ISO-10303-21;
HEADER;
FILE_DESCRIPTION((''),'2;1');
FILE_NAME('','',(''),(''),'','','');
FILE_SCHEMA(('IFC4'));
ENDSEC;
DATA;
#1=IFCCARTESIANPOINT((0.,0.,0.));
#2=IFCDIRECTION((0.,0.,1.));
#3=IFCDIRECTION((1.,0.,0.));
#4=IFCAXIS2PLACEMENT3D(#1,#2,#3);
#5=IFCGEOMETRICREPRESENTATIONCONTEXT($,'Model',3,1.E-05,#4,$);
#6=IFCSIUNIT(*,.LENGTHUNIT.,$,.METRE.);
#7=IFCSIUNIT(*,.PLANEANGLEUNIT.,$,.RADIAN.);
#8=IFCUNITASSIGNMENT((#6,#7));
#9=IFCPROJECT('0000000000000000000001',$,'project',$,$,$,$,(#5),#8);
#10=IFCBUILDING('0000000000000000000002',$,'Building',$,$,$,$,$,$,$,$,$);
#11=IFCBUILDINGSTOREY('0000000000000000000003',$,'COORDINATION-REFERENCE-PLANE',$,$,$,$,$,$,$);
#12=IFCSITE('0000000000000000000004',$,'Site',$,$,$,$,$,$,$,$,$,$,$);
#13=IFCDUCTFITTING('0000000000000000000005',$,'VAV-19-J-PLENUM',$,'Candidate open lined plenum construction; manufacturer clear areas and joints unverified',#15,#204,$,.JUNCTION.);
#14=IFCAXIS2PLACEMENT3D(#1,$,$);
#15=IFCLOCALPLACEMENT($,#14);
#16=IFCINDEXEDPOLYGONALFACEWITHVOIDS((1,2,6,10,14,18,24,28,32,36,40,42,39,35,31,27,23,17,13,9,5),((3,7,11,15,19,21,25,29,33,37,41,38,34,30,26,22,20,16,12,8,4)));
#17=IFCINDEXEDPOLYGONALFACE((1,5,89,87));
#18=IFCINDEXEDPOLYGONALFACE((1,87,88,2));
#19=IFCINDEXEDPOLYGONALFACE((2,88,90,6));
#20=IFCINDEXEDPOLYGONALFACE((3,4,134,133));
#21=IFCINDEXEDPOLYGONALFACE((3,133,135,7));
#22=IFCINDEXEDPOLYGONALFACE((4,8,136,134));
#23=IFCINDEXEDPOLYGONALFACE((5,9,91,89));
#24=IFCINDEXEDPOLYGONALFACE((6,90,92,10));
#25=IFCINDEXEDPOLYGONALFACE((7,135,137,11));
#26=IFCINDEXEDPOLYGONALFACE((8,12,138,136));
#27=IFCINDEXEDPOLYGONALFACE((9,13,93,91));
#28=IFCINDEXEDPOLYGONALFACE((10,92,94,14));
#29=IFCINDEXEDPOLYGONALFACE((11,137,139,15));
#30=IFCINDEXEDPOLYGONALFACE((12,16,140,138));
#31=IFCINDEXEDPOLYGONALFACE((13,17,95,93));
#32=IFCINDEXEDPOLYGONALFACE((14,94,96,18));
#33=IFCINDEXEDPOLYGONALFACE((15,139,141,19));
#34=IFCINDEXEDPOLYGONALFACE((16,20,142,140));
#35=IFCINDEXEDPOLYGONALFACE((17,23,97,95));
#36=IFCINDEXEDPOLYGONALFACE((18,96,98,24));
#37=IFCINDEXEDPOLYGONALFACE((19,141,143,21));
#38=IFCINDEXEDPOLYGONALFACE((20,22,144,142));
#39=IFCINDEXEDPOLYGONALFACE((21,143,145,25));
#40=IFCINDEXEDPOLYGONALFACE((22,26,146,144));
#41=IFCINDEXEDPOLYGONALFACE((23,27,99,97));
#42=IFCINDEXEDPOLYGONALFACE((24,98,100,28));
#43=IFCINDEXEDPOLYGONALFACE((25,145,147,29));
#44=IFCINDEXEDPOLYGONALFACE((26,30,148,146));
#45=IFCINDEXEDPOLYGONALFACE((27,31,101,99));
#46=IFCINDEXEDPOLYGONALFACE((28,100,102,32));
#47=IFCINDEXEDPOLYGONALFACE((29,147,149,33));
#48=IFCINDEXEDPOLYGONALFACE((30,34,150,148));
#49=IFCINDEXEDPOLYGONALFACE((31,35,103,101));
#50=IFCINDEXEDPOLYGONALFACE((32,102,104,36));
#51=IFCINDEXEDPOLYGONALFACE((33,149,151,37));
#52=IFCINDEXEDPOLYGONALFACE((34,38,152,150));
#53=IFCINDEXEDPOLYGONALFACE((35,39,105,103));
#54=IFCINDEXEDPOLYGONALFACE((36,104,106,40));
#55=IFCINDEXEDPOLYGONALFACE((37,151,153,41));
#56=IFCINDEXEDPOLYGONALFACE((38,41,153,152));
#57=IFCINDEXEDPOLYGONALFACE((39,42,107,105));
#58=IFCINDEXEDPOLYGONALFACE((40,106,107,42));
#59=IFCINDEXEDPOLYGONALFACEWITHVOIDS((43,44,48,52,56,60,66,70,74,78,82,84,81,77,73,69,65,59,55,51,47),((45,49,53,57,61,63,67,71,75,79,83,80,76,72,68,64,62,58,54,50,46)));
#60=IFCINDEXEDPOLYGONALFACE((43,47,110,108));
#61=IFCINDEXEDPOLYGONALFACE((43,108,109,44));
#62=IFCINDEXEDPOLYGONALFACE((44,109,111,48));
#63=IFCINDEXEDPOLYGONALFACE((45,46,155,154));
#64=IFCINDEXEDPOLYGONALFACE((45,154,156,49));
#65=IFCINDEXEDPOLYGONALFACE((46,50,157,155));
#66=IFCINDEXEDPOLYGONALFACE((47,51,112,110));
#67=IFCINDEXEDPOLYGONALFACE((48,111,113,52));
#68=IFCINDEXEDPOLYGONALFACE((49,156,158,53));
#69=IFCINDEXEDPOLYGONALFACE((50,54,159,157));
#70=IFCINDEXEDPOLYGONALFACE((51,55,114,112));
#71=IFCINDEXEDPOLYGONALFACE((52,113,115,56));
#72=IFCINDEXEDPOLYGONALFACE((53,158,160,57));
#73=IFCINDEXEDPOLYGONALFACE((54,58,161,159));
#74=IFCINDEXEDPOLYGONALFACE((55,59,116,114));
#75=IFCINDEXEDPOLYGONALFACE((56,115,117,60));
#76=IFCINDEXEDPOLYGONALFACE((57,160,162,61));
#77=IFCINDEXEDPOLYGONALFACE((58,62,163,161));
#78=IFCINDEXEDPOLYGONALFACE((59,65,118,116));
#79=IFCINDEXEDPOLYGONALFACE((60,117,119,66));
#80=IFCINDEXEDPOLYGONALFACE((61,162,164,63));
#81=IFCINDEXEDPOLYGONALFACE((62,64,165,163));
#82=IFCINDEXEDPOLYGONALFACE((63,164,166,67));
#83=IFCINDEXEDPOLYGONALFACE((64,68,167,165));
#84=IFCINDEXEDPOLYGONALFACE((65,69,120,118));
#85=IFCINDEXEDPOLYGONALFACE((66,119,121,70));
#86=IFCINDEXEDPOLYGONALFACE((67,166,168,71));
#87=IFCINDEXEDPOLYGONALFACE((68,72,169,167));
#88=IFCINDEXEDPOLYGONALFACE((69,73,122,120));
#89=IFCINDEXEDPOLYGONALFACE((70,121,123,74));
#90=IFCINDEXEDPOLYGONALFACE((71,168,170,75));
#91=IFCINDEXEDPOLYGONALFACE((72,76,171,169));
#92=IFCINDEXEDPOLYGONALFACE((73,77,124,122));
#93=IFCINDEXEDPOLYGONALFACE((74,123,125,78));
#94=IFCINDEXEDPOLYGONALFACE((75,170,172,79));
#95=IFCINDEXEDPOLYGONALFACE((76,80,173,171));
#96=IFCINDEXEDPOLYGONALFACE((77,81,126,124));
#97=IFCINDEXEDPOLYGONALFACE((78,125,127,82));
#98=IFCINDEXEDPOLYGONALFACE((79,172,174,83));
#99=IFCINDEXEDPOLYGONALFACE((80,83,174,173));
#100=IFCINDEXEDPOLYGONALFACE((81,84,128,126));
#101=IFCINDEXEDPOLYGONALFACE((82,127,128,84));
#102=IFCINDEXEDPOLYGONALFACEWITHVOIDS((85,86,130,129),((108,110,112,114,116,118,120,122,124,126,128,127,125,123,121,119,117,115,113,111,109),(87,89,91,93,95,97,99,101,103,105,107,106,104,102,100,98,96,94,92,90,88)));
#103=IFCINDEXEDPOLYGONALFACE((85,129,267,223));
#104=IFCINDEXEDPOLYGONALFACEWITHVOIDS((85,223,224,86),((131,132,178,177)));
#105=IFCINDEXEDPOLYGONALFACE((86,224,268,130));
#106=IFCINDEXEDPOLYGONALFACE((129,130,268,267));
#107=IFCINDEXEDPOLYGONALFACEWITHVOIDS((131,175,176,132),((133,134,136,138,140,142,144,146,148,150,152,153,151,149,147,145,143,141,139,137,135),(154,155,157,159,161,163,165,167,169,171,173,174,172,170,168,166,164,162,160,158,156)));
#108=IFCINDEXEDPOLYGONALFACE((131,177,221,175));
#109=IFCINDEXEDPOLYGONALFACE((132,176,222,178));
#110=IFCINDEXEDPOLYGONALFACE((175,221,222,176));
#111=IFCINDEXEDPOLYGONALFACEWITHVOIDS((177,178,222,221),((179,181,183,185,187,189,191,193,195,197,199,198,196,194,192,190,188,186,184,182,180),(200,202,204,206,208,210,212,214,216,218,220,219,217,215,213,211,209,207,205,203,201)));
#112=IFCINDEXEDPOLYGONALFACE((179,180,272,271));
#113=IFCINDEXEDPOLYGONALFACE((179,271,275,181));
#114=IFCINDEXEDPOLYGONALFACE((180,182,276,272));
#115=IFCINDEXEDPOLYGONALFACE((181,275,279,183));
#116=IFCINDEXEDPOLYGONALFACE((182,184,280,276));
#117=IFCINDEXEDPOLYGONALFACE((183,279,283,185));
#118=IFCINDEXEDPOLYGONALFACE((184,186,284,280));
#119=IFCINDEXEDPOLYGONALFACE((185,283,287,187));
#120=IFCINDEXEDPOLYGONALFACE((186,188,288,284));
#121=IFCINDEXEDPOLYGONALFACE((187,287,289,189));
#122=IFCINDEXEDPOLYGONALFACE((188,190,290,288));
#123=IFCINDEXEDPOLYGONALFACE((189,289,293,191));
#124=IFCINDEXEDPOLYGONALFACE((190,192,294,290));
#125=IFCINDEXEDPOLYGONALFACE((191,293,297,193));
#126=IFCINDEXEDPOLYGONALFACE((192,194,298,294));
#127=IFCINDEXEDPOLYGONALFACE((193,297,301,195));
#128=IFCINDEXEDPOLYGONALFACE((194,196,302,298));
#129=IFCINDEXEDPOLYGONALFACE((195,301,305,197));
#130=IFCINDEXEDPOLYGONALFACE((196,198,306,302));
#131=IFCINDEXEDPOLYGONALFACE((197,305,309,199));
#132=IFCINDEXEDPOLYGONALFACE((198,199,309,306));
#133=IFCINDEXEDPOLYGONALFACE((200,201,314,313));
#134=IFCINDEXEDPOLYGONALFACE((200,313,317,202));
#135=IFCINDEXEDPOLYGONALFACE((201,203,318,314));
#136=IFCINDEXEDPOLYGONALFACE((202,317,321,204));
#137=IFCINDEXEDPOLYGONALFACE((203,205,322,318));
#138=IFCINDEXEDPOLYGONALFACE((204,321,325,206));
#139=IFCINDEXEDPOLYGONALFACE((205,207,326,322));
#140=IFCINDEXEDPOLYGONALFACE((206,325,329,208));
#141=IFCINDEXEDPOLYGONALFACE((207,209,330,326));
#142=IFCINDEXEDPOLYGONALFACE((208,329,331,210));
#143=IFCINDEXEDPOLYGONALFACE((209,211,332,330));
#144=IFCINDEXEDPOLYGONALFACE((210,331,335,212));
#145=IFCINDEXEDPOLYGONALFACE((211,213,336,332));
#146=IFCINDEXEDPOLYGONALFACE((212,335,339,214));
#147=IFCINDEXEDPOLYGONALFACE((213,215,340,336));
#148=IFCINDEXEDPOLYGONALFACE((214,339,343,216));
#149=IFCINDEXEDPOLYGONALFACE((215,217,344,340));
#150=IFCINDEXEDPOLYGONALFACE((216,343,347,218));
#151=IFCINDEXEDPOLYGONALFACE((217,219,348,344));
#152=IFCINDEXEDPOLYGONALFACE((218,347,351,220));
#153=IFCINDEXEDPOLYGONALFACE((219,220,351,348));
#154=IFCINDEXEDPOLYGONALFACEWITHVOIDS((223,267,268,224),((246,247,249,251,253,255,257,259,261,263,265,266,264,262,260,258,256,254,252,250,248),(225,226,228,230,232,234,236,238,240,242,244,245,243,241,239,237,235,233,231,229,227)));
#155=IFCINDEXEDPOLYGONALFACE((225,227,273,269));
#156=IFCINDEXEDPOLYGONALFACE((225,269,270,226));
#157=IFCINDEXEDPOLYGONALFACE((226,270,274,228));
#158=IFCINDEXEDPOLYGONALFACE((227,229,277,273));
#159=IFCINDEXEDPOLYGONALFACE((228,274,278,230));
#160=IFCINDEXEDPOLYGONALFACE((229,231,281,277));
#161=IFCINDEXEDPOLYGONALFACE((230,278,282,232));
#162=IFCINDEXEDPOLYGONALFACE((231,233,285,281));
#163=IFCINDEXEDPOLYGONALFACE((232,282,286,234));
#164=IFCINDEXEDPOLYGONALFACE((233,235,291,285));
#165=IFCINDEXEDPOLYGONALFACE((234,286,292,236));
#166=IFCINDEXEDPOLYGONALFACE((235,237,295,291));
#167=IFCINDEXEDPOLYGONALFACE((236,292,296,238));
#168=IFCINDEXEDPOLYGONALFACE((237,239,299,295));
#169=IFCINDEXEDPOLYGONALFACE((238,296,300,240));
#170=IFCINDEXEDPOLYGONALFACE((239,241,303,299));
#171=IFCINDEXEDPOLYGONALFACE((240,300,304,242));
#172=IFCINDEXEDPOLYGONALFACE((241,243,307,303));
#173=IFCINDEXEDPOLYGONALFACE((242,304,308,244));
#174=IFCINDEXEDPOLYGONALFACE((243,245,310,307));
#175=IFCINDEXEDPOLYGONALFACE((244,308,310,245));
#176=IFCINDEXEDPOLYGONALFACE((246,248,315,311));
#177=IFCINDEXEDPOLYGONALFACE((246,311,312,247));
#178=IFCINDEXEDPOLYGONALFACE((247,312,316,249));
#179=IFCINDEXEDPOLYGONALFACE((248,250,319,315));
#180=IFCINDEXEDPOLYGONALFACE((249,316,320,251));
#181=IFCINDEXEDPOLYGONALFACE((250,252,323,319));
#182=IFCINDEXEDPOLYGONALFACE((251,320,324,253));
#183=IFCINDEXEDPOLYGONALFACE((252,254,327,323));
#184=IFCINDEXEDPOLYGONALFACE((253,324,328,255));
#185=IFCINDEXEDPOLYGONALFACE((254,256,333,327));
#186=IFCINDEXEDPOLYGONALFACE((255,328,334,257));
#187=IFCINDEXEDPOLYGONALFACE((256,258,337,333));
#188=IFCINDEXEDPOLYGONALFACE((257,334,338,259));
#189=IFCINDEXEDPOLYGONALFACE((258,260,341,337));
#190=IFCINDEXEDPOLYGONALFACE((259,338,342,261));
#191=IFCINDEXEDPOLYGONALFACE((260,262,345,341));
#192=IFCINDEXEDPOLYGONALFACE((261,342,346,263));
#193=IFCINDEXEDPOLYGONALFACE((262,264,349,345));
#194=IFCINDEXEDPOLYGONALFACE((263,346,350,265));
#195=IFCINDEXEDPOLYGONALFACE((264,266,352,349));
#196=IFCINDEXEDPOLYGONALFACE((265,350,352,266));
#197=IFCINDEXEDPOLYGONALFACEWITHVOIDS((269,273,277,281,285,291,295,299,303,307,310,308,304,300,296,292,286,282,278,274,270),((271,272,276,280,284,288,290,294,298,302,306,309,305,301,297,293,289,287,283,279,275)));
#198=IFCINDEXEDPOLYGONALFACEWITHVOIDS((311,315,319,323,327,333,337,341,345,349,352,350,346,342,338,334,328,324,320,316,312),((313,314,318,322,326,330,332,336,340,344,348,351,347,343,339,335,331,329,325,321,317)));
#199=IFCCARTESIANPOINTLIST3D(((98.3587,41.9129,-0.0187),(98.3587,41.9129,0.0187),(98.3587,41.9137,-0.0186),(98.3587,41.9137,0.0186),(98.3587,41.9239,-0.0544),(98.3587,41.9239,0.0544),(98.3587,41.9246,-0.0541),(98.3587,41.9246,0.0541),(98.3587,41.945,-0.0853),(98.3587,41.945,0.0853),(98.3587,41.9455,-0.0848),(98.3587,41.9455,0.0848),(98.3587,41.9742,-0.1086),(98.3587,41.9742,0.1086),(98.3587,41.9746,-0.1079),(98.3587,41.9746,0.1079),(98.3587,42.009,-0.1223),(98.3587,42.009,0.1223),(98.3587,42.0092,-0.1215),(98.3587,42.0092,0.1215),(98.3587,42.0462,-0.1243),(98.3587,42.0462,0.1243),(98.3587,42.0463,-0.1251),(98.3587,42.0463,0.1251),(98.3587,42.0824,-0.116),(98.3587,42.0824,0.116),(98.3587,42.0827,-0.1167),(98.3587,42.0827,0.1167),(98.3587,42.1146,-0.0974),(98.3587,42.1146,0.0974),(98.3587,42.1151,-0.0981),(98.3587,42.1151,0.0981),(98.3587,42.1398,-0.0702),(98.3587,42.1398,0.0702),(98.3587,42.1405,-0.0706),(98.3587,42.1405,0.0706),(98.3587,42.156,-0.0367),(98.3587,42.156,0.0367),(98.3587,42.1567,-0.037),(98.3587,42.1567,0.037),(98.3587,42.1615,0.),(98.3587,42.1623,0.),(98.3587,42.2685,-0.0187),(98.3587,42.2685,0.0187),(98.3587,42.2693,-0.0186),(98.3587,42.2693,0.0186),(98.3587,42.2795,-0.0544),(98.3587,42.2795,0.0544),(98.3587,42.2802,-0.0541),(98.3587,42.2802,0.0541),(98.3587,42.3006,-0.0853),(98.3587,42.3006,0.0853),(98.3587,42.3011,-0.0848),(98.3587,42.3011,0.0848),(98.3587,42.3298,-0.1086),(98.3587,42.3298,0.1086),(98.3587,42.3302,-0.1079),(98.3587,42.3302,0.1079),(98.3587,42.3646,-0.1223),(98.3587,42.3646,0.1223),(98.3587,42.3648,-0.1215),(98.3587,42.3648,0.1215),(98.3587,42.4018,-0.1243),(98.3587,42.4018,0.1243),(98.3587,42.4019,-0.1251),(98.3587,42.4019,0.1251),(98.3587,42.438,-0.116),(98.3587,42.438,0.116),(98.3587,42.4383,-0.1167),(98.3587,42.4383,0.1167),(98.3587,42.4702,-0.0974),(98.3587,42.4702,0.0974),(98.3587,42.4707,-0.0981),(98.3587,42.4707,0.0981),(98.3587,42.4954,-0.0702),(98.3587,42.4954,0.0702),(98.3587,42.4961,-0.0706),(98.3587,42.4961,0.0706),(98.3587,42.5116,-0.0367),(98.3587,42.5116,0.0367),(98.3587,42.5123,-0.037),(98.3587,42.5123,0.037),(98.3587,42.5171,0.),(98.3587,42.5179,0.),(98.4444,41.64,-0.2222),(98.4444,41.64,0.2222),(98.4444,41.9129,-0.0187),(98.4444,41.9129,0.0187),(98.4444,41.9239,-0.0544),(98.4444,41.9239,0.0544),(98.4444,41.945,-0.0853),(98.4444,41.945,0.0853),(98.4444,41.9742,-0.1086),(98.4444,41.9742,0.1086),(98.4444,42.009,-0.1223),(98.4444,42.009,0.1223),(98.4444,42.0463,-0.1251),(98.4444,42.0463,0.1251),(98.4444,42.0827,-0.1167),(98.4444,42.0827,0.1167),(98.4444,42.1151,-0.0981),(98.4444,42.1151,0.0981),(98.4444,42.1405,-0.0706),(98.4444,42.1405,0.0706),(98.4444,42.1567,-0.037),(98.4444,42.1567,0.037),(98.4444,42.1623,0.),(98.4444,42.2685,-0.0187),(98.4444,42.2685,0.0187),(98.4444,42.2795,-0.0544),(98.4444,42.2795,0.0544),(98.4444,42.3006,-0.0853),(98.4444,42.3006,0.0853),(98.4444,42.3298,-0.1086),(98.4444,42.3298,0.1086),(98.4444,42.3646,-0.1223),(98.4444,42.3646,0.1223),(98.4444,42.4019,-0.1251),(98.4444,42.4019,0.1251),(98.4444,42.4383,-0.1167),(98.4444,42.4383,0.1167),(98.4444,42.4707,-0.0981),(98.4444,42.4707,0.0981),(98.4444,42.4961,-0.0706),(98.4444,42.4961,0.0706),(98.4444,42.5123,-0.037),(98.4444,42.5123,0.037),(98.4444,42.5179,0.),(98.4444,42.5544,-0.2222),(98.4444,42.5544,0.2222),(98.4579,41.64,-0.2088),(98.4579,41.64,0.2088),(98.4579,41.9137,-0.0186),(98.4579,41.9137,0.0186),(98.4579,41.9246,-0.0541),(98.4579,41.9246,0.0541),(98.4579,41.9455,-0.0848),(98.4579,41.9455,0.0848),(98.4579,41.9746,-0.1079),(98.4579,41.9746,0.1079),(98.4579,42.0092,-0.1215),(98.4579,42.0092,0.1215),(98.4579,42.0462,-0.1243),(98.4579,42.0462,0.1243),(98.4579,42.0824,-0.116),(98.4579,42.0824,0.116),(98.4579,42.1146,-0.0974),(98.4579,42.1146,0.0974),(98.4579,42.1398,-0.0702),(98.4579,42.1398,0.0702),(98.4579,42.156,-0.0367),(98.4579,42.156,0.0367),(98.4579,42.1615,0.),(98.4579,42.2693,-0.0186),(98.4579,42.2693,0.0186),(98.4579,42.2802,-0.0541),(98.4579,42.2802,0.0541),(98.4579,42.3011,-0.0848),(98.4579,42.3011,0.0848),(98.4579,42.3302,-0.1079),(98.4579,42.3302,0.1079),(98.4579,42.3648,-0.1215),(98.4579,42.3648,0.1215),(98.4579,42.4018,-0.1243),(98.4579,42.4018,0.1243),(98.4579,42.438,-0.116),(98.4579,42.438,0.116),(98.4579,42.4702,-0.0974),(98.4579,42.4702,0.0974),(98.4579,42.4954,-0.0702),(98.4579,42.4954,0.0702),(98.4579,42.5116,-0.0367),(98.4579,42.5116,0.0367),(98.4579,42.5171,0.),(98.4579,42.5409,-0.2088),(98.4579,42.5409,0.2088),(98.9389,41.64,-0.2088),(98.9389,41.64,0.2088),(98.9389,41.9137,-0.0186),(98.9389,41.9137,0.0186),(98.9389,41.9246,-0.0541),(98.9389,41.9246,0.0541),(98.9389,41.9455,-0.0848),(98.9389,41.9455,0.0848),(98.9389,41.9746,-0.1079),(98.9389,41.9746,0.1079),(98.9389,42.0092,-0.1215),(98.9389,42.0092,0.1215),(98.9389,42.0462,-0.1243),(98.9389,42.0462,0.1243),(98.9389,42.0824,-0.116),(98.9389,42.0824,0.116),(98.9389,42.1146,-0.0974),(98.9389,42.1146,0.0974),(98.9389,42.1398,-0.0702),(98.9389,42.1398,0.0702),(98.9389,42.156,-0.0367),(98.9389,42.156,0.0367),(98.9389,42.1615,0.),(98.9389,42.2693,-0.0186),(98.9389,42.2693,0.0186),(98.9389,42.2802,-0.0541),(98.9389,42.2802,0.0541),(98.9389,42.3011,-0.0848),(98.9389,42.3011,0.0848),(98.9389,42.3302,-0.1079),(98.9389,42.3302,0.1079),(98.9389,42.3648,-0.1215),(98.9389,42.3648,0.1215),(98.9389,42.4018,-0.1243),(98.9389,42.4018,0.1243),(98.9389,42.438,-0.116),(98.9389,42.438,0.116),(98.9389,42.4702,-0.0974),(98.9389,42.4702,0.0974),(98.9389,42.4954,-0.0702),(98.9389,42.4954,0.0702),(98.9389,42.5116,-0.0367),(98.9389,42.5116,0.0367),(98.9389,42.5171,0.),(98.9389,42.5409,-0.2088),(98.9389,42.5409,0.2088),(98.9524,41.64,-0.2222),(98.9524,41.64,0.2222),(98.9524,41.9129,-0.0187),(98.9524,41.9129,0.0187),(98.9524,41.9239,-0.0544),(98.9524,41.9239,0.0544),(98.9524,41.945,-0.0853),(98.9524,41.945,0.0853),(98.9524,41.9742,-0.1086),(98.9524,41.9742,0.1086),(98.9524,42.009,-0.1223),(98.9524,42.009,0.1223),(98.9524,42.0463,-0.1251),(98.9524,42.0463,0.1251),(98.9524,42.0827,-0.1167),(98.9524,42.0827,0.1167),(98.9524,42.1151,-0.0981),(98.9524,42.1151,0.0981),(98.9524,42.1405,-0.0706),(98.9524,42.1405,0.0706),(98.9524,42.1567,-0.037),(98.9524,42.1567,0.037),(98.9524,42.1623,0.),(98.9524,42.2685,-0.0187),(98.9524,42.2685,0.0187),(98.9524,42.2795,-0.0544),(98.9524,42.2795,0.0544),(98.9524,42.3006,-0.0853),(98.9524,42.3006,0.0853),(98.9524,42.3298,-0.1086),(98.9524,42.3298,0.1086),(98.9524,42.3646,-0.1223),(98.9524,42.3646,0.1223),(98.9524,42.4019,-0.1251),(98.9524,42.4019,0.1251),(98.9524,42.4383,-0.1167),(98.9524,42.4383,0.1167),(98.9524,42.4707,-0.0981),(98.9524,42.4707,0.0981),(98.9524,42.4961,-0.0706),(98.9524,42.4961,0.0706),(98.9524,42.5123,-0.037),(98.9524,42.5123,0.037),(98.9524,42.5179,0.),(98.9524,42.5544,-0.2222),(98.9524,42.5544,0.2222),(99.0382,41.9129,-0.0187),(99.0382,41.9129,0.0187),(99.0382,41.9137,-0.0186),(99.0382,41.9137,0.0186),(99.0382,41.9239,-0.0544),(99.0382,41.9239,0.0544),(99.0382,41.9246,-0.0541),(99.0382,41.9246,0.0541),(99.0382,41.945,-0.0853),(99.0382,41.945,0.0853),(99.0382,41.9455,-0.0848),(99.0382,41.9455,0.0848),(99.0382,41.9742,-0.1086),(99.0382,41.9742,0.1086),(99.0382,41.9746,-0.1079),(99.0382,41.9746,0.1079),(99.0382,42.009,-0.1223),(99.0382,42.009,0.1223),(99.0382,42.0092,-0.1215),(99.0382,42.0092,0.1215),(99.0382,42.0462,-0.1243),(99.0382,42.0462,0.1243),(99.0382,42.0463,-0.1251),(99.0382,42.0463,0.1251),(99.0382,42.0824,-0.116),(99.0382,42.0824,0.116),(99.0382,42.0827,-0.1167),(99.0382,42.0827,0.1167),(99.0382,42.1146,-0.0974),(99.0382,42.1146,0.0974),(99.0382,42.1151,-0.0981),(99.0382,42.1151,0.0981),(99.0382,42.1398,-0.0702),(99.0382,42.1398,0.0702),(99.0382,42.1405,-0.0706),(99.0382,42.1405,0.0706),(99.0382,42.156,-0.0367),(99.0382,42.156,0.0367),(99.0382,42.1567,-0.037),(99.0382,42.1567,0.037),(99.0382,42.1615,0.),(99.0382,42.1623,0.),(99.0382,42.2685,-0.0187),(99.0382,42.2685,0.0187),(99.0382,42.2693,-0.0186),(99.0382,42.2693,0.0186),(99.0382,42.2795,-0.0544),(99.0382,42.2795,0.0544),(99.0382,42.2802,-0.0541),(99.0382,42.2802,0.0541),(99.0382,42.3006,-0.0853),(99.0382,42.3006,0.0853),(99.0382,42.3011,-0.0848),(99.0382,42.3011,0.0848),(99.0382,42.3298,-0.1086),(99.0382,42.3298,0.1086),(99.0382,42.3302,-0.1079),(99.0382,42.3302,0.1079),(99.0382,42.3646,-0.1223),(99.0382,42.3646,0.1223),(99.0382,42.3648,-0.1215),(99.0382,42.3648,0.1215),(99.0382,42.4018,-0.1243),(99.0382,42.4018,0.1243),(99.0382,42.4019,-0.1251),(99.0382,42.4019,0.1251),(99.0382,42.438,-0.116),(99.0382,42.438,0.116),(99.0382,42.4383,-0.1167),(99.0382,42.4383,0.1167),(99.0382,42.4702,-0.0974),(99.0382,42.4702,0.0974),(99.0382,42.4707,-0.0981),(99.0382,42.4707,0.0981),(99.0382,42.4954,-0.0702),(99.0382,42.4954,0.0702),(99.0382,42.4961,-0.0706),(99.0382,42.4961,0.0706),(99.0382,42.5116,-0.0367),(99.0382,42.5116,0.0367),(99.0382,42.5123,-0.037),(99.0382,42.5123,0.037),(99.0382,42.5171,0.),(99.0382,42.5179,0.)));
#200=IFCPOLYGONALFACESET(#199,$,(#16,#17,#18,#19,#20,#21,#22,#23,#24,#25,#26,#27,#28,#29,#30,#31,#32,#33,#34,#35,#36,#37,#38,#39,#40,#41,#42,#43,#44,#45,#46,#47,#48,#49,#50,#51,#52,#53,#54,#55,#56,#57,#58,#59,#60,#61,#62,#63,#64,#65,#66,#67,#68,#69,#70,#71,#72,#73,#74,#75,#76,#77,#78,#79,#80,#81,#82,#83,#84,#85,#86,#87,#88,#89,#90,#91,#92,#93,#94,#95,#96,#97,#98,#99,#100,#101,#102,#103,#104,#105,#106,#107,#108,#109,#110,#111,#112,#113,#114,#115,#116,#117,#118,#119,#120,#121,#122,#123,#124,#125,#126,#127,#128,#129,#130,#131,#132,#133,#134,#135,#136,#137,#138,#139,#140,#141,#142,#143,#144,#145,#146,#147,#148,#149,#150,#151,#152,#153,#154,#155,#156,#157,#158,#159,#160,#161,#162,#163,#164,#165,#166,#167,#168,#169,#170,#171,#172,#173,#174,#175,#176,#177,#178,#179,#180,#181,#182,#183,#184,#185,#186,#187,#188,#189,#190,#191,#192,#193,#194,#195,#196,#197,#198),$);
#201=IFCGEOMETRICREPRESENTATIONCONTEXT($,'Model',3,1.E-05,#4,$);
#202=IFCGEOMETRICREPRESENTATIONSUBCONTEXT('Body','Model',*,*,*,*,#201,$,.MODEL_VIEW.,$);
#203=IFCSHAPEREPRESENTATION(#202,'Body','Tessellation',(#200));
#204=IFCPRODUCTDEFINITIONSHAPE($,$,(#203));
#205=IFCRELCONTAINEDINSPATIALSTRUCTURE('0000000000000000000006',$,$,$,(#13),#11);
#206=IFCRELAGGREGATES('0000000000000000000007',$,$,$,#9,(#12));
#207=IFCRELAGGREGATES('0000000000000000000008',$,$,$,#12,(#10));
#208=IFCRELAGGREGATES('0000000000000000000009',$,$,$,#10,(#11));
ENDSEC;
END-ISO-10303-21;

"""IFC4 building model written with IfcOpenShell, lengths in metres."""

from ifc_helpers import new_model, si_unit, frame, origin_with_axes, place, context, subcontext, project, spatial, rectangle, circle, extrude, boolean, element, save


model = new_model("IFC4")

# Units and contexts
model_context_1 = context("Model", 3, precision=1e-05, world=origin_with_axes())
model_context_2 = context("Model", 3, precision=1e-05, world=origin_with_axes())
body_context_1 = subcontext(model_context_2, "Body", "Model", "MODEL_VIEW")
ifc_project = project(units=[si_unit("LENGTHUNIT", "METRE"), si_unit("PLANEANGLEUNIT", "RADIAN")], contexts=[model_context_1])

# Site, building, storey
site = spatial("IfcSite", under=ifc_project, Name="Site")
building = spatial("IfcBuilding", under=site, Name="Building")
storey = spatial("IfcBuildingStorey", under=building, Name="COORDINATION-REFERENCE-PLANE")

# Duct fitting
duct_fitting_1_placement = place(None, frame((98.4444, 41.64, -0.2223), z_axis=(0.0, 0.0, 1.0), x_axis=(1.0, 0.0, 0.0)))
solid_1 = boolean("UNION", boolean("UNION", boolean("UNION", boolean("UNION", extrude(rectangle(XDim=0.481, YDim=0.4175), frame((0.254, -0.01, 0.2223), z_axis=(0.0, 1.0, 0.0), x_axis=(-1.0, 0.0, 0.0)), (0.0, 0.0, 1.0), 0.9109), extrude(circle(Radius=0.1246), frame((0.4845, 0.3969, 0.2223), z_axis=(1.0, 0.0, 0.0), x_axis=(0.0, 1.0, 0.0)), (0.0, 0.0, 1.0), 0.1192)), extrude(circle(Radius=0.1246), frame((0.0235, 0.3969, 0.2223), z_axis=(-1.0, 0.0, 0.0), x_axis=(0.0, 1.0, 0.0)), (0.0, 0.0, 1.0), 0.1192)), extrude(circle(Radius=0.1246), frame((0.4845, 0.7525, 0.2223), z_axis=(1.0, 0.0, 0.0), x_axis=(0.0, 1.0, 0.0)), (0.0, 0.0, 1.0), 0.1192)), extrude(circle(Radius=0.1246), frame((0.0235, 0.7525, 0.2223), z_axis=(-1.0, 0.0, 0.0), x_axis=(0.0, 1.0, 0.0)), (0.0, 0.0, 1.0), 0.1192))
element("IfcDuctFitting", 1, at=duct_fitting_1_placement, inside=storey, Name="VAV-19-J-PLENUM", ObjectType="Candidate open lined plenum construction; manufacturer clear areas and joints unverified", PredefinedType="JUNCTION", context=body_context_1, shape_type="CSG", body=[
    boolean("DIFFERENCE", boolean("UNION", boolean("UNION", boolean("UNION", boolean("UNION", extrude(rectangle(XDim=0.508, YDim=0.4445), frame((0.254, 0.0, 0.2223), z_axis=(0.0, 1.0, 0.0), x_axis=(-1.0, 0.0, 0.0)), (0.0, 0.0, 1.0), 0.9144), extrude(circle(Radius=0.1254), frame((0.4845, 0.3969, 0.2223), z_axis=(1.0, 0.0, 0.0), x_axis=(0.0, 1.0, 0.0)), (0.0, 0.0, 1.0), 0.1092)), extrude(circle(Radius=0.1254), frame((0.0235, 0.3969, 0.2223), z_axis=(-1.0, 0.0, 0.0), x_axis=(0.0, 1.0, 0.0)), (0.0, 0.0, 1.0), 0.1092)), extrude(circle(Radius=0.1254), frame((0.4845, 0.7525, 0.2223), z_axis=(1.0, 0.0, 0.0), x_axis=(0.0, 1.0, 0.0)), (0.0, 0.0, 1.0), 0.1092)), extrude(circle(Radius=0.1254), frame((0.0235, 0.7525, 0.2223), z_axis=(-1.0, 0.0, 0.0), x_axis=(0.0, 1.0, 0.0)), (0.0, 0.0, 1.0), 0.1092)), solid_1),
])

save(model, "model.ifc")
